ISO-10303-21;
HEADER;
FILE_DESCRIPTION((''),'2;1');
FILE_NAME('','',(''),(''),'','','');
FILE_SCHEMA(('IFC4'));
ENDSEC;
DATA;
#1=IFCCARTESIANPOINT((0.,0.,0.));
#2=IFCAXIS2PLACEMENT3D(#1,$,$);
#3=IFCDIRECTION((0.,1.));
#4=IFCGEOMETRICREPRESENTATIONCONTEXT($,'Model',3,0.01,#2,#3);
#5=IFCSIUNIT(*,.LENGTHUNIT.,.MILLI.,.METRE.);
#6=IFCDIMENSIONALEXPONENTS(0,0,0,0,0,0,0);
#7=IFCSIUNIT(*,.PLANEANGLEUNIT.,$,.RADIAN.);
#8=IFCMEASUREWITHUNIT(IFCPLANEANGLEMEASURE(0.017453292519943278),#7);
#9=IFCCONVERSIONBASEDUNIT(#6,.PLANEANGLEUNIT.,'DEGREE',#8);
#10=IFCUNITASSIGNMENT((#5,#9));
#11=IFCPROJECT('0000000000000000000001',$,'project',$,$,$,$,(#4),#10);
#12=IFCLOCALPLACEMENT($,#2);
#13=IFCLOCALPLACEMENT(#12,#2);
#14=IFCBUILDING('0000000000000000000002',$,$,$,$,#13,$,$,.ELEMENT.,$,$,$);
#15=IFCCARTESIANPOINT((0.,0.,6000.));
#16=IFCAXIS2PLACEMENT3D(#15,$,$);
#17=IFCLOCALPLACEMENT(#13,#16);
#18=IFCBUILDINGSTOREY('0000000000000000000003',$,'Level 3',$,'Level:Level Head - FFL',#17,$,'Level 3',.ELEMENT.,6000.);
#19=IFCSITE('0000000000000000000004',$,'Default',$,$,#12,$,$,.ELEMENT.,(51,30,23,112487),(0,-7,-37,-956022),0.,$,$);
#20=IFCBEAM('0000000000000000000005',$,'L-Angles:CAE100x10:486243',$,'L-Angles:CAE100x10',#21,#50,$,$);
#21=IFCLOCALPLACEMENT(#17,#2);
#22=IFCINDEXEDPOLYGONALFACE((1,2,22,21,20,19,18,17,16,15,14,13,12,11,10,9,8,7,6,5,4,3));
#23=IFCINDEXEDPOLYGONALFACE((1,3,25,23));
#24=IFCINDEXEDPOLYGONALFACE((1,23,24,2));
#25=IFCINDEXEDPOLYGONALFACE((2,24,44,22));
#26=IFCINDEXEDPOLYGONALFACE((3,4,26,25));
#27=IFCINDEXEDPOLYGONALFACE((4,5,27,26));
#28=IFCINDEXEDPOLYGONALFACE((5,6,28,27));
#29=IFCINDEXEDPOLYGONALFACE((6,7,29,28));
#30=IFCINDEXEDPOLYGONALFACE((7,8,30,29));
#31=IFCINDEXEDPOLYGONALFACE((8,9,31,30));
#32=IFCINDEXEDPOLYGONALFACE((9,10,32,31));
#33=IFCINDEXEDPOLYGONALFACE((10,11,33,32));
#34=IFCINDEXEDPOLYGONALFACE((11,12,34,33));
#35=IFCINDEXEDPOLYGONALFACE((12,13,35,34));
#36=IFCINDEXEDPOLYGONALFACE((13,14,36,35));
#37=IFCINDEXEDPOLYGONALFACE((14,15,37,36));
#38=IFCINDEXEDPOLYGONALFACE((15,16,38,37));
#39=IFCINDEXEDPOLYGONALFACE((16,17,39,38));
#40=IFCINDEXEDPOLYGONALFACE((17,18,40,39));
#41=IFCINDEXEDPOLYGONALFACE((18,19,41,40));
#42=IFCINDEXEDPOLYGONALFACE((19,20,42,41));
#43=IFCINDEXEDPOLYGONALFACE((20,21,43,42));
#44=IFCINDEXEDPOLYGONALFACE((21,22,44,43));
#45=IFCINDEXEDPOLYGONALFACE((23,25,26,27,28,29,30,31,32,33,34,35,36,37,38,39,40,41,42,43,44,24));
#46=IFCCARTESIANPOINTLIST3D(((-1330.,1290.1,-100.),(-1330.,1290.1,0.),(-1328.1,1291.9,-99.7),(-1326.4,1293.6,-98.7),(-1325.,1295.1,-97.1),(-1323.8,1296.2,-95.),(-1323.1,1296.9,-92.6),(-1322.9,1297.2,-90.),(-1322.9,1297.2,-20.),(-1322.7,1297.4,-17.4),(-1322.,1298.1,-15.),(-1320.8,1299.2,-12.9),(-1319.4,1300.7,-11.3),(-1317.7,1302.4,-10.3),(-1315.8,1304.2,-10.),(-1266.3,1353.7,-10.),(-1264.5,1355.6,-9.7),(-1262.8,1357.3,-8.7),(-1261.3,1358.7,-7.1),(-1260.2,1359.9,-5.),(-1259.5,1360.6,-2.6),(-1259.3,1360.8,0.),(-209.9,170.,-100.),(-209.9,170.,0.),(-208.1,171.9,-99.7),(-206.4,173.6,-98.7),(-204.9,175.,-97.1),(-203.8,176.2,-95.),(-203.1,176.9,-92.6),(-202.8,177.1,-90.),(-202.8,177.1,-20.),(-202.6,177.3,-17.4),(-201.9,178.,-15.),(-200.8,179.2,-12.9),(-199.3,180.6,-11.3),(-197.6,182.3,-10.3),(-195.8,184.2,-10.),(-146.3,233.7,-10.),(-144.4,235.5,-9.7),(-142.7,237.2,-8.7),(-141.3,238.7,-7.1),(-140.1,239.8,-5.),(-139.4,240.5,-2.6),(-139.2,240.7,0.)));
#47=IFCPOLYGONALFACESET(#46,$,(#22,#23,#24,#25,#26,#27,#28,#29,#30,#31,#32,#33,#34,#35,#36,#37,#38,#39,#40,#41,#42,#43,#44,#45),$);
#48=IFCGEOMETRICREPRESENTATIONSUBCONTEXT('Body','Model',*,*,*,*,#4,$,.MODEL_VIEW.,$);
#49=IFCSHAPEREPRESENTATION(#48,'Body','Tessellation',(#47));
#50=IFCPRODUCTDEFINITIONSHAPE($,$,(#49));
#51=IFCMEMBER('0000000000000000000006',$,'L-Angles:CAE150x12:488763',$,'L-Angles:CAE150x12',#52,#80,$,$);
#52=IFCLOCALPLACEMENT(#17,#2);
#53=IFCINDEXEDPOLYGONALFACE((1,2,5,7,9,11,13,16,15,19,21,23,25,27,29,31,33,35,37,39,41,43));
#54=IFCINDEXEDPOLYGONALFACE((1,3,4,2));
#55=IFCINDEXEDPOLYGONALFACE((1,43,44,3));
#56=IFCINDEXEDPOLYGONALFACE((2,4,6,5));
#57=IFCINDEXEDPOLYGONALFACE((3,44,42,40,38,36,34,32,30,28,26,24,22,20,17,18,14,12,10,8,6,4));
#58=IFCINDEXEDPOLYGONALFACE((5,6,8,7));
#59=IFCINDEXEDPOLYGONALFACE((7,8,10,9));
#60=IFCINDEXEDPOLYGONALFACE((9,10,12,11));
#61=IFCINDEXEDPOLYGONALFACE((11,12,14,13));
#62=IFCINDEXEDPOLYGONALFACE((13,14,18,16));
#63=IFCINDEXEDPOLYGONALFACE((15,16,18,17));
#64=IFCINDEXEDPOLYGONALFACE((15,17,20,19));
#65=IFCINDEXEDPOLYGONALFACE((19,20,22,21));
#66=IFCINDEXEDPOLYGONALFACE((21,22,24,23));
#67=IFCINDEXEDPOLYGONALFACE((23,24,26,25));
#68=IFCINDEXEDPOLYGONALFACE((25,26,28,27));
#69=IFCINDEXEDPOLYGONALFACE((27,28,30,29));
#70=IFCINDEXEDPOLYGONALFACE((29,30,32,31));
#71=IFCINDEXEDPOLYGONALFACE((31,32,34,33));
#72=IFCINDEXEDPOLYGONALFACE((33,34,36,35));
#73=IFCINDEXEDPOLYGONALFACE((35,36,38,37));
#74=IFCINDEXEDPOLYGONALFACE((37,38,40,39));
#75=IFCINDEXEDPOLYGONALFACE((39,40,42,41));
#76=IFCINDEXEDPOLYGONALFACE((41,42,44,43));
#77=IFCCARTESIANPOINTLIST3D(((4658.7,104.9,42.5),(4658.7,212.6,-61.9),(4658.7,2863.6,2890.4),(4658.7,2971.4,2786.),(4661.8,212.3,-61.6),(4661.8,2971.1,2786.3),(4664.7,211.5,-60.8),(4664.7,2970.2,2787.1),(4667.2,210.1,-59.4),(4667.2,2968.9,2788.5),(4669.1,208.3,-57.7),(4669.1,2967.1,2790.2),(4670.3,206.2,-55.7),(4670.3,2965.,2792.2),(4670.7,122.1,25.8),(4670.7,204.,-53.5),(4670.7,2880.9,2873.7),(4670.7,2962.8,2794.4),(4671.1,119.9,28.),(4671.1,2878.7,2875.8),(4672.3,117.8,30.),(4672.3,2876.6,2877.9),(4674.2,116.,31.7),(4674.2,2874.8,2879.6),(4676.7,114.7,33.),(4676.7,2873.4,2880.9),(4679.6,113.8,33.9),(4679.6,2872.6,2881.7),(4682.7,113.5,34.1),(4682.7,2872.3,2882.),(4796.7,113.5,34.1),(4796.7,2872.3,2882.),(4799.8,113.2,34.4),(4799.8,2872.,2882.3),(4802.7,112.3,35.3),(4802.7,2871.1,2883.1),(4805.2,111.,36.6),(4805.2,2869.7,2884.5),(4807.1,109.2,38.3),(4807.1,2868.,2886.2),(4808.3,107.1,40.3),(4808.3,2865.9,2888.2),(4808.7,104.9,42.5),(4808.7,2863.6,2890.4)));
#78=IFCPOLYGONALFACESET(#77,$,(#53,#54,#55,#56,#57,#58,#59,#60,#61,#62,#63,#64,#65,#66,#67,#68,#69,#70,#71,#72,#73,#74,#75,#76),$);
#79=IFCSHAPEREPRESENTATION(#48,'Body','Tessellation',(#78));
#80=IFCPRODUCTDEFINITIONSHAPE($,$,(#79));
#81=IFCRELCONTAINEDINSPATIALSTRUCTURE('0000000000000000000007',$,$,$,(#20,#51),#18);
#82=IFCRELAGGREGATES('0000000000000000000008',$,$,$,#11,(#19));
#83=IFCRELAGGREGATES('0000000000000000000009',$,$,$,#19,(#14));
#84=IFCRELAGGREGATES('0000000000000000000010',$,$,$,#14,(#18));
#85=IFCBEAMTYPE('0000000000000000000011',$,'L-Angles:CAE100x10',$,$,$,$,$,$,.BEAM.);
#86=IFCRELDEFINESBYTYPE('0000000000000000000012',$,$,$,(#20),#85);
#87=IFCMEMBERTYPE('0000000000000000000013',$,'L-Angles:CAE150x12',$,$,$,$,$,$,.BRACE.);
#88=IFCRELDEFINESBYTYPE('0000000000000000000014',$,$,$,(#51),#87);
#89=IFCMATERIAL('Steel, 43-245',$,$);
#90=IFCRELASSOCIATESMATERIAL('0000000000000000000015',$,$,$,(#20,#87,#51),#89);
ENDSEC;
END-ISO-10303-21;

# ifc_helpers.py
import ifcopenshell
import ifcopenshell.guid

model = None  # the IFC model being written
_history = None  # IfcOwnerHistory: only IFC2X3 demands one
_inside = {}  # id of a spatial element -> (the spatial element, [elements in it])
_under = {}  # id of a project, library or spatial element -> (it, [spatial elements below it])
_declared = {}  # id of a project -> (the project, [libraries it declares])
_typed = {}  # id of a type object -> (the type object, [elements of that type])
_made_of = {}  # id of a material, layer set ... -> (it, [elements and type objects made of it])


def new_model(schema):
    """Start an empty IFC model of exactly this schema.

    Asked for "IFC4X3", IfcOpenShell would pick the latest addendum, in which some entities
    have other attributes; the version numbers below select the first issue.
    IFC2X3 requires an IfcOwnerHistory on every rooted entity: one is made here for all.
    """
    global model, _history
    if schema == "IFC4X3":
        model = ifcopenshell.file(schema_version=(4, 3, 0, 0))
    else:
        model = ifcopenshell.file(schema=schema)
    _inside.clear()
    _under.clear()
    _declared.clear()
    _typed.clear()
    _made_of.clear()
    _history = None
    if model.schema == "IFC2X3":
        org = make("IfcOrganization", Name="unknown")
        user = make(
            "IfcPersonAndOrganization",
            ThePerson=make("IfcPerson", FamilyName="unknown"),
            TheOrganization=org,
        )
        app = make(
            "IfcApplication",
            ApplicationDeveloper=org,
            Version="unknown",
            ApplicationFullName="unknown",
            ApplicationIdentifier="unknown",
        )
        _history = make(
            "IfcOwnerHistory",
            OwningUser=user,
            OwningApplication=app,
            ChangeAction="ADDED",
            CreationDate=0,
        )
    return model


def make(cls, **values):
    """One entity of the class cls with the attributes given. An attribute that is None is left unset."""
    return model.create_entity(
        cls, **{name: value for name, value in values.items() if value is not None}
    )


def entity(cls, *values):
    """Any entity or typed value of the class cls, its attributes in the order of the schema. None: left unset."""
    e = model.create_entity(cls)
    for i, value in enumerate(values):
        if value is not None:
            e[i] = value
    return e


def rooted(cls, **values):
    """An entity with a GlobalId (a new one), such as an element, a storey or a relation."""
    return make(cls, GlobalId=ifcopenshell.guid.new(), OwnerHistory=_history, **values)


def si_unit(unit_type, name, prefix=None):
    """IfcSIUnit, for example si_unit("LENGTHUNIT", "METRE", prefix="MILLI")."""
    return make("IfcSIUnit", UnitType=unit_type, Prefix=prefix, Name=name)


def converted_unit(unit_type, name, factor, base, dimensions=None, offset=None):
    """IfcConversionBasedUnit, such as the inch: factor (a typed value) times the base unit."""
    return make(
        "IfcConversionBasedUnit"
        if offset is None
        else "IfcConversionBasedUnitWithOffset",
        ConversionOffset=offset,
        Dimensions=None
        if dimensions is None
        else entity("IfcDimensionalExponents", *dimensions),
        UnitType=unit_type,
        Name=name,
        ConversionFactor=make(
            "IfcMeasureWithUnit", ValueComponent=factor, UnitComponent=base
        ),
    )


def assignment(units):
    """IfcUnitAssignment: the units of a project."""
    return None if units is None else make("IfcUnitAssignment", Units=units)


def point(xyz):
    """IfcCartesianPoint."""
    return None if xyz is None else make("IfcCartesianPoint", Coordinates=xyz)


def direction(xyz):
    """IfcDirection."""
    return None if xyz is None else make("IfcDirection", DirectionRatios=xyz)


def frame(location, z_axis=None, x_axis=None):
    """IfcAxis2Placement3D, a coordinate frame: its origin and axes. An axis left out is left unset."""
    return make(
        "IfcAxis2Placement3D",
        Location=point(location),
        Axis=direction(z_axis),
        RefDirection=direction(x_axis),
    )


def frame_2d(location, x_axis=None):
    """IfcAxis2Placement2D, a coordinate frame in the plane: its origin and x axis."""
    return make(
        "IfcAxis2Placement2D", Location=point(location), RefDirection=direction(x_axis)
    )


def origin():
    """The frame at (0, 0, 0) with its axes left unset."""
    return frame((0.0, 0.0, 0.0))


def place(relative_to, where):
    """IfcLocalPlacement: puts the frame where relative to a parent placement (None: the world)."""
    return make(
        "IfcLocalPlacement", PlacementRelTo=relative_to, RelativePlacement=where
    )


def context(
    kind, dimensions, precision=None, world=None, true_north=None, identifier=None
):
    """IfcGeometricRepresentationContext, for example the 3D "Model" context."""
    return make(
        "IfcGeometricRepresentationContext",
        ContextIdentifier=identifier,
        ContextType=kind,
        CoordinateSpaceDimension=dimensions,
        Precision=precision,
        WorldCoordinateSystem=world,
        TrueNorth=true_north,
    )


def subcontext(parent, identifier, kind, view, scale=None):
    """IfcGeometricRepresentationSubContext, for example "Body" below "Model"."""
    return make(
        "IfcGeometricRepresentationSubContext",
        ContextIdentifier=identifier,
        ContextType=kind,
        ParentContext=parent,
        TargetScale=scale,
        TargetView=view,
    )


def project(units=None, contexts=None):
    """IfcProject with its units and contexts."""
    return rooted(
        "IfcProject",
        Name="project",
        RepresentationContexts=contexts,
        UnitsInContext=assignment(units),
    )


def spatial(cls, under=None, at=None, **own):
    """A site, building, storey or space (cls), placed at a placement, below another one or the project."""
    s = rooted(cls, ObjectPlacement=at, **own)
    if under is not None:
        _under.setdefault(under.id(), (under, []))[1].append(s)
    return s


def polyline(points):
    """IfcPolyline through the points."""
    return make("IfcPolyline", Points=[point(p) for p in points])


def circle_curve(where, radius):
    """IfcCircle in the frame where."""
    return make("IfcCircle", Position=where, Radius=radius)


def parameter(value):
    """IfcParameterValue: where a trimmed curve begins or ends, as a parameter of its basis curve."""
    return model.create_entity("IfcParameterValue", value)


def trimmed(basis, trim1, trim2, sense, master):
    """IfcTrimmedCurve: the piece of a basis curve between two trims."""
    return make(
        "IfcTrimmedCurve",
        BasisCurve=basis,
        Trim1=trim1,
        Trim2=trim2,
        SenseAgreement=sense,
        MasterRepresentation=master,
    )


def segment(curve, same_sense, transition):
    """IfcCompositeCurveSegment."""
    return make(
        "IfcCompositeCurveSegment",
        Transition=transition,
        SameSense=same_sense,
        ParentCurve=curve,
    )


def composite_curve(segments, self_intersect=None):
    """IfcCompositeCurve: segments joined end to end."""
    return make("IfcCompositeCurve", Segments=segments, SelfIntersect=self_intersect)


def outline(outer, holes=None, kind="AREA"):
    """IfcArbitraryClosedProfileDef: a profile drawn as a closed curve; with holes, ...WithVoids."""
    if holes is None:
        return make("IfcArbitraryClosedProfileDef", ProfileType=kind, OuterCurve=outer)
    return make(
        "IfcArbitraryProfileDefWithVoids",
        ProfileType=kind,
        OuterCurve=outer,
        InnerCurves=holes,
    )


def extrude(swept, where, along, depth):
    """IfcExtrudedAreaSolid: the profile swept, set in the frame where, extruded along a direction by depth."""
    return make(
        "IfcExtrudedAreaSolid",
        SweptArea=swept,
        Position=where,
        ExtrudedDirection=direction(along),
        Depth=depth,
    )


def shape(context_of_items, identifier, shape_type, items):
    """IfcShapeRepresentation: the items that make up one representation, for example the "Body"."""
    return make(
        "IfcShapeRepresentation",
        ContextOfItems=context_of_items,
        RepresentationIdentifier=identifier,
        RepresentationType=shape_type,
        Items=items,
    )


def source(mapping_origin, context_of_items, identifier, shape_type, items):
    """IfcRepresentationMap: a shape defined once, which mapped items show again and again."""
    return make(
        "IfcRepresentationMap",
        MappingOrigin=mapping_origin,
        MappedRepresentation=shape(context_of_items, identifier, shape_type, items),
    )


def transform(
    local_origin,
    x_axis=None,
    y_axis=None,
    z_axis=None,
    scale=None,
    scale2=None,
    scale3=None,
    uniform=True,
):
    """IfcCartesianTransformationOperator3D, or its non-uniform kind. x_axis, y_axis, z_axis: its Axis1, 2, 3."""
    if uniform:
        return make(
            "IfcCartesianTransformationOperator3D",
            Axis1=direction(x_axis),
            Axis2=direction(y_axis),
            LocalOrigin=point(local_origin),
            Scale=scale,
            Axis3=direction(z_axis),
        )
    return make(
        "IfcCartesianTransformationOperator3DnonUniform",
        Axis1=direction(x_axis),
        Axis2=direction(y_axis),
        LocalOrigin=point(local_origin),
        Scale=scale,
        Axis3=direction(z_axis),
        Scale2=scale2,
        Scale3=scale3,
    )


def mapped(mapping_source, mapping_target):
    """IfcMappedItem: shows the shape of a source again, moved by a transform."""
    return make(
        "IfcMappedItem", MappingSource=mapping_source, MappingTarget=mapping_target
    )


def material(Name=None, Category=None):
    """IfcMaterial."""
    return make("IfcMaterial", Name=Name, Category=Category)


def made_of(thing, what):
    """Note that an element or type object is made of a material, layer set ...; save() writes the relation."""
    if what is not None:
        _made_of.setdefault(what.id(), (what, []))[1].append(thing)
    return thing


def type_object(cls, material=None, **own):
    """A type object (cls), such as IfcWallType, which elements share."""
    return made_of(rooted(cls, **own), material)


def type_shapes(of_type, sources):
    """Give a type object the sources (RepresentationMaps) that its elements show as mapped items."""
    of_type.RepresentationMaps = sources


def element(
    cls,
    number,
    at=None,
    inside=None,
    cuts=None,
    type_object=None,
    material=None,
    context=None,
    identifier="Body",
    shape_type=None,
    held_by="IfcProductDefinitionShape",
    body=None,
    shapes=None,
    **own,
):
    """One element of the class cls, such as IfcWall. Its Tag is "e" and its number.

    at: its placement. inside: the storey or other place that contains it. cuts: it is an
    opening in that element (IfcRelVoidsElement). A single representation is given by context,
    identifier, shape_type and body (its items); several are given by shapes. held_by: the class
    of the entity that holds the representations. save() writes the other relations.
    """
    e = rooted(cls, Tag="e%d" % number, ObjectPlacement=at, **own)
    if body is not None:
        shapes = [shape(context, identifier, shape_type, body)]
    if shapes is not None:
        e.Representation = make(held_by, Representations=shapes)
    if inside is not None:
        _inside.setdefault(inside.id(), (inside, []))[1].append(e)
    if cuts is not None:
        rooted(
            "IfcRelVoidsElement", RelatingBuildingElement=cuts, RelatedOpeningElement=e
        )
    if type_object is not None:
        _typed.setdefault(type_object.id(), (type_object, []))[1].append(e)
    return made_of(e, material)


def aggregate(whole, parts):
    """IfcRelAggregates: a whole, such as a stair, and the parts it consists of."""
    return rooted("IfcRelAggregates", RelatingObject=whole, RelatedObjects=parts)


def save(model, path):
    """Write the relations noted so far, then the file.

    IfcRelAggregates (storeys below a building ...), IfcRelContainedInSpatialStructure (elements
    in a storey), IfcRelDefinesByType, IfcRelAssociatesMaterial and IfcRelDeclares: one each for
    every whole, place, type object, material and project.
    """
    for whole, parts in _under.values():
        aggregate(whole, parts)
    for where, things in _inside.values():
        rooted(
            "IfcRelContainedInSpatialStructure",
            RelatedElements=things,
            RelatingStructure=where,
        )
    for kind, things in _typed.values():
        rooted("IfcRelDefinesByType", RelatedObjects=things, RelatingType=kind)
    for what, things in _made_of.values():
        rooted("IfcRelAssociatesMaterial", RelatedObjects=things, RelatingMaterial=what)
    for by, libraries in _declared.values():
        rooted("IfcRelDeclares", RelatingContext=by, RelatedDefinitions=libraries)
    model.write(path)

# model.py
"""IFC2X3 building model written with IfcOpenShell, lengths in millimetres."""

from ifc_helpers import new_model, entity, si_unit, converted_unit, direction, frame, frame_2d, origin, place, context, subcontext, project, spatial, polyline, circle_curve, parameter, trimmed, segment, composite_curve, outline, extrude, source, transform, mapped, material, type_object, type_shapes, element, save


model = new_model("IFC2X3")

# Units and contexts
model_context = context("Model", 3, precision=0.01, world=origin(), true_north=direction((0.0, 1.0)))
body_context = subcontext(model_context, "Body", "Model", "MODEL_VIEW")
ifc_project = project(units=[si_unit("LENGTHUNIT", "METRE", prefix="MILLI"), converted_unit("PLANEANGLEUNIT", "DEGREE", entity("IfcPlaneAngleMeasure", 0.017453292519943278), si_unit("PLANEANGLEUNIT", "RADIAN"), dimensions=[0, 0, 0, 0, 0, 0, 0])], contexts=[model_context])

# Site, building, storey
site_placement = place(None, origin())
site = spatial("IfcSite", under=ifc_project, at=site_placement, Name="Default", CompositionType="ELEMENT", RefLatitude=(51, 30, 23, 112487), RefLongitude=(0, -7, -37, -956022), RefElevation=0.0)
building_placement = place(site_placement, origin())
building = spatial("IfcBuilding", under=site, at=building_placement, CompositionType="ELEMENT")
storey_placement = place(building_placement, frame((0.0, 0.0, 6000.0)))
storey = spatial("IfcBuildingStorey", under=building, at=storey_placement, Name="Level 3", ObjectType="Level:Level Head - FFL", LongName="Level 3", CompositionType="ELEMENT", Elevation=6000.0)

# Beam
ifc_material = material(Name="Steel, 43-245")
beam_type_1 = type_object("IfcBeamType", Name="L-Angles:CAE100x10", PredefinedType="BEAM")
beam_1_placement = place(storey_placement, frame((0.0, 0.0, 0.0), z_axis=(0.0, 0.0, 1.0), x_axis=(-0.707107, 0.707107, 0.0)))
element("IfcBeam", 1, at=beam_1_placement, inside=storey, type_object=beam_type_1, material=ifc_material, Name="L-Angles:CAE100x10:486243", ObjectType="L-Angles:CAE100x10", context=body_context, shape_type="SweptSolid", body=[
    extrude(outline(composite_curve([segment(polyline([(-67.1, -32.9), (32.9, -32.9)]), True, "CONTINUOUS"), segment(polyline([(32.9, -32.9), (32.9, 67.1)]), True, "CONTINUOUS"), segment(trimmed(circle_curve(frame_2d((32.9, 57.1), x_axis=(0.0, 1.0)), 10.0), [parameter(0.0)], [parameter(90.0)], True, "PARAMETER"), True, "CONTINUOUS"), segment(polyline([(22.9, 57.1), (22.9, -12.9)]), True, "CONTINUOUS"), segment(trimmed(circle_curve(frame_2d((12.9, -12.9), x_axis=(1.0, 0.0)), 10.0), [parameter(270.0)], [parameter(0.0)], True, "PARAMETER"), False, "CONTINUOUS"), segment(polyline([(12.9, -22.9), (-57.1, -22.9)]), True, "CONTINUOUS"), segment(trimmed(circle_curve(frame_2d((-57.1, -32.9), x_axis=(0.0, 1.0)), 10.0), [parameter(0.0)], [parameter(90.0)], True, "PARAMETER"), True, "CONTINUOUS")], self_intersect=False)), frame((268.7, -4.7, -32.9), z_axis=(1.0, 0.0, 0.0), x_axis=(0.0, 0.0, 1.0)), (0.0, 0.0, 1.0), 1584.0),
])

# Member
member_type = type_object("IfcMemberType", Name="L-Angles:CAE150x12", PredefinedType="BRACE", material=ifc_material)
shared_shape = source(origin(), body_context, "Body", "SweptSolid", [
    extrude(outline(composite_curve([segment(polyline([(-102.0, -48.0), (48.0, -48.0)]), True, "CONTINUOUS"), segment(polyline([(48.0, -48.0), (48.0, 102.0)]), True, "CONTINUOUS"), segment(trimmed(circle_curve(frame_2d((48.0, 90.0), x_axis=(0.0, 1.0)), 12.0), [parameter(0.0)], [parameter(90.0)], True, "PARAMETER"), True, "CONTINUOUS"), segment(polyline([(36.0, 90.0), (36.0, -24.0)]), True, "CONTINUOUS"), segment(trimmed(circle_curve(frame_2d((24.0, -24.0), x_axis=(1.0, 0.0)), 12.0), [parameter(270.0)], [parameter(0.0)], True, "PARAMETER"), False, "CONTINUOUS"), segment(polyline([(24.0, -36.0), (-90.0, -36.0)]), True, "CONTINUOUS"), segment(trimmed(circle_curve(frame_2d((-90.0, -48.0), x_axis=(0.0, 1.0)), 12.0), [parameter(0.0)], [parameter(90.0)], True, "PARAMETER"), True, "CONTINUOUS")], self_intersect=False)), frame((-1962.5, -6.8, -6.8), z_axis=(1.0, 0.0, 0.0), x_axis=(0.0, 0.0, 1.0)), (0.0, 0.0, 1.0), 3965.0),
])
type_shapes(member_type, [shared_shape])
member_placement = place(storey_placement, frame((4699.9, 1499.9, 1423.4), z_axis=(0.0, -0.718256, 0.695779), x_axis=(0.0, 0.695779, 0.718256)))
element("IfcMember", 2, at=member_placement, inside=storey, type_object=member_type, material=ifc_material, Name="L-Angles:CAE150x12:488763", ObjectType="L-Angles:CAE150x12", context=body_context, shape_type="MappedRepresentation", body=[
    mapped(shared_shape, transform((0.0, 0.0, 0.0), scale=1.0)),
])

save(model, "model.ifc")
